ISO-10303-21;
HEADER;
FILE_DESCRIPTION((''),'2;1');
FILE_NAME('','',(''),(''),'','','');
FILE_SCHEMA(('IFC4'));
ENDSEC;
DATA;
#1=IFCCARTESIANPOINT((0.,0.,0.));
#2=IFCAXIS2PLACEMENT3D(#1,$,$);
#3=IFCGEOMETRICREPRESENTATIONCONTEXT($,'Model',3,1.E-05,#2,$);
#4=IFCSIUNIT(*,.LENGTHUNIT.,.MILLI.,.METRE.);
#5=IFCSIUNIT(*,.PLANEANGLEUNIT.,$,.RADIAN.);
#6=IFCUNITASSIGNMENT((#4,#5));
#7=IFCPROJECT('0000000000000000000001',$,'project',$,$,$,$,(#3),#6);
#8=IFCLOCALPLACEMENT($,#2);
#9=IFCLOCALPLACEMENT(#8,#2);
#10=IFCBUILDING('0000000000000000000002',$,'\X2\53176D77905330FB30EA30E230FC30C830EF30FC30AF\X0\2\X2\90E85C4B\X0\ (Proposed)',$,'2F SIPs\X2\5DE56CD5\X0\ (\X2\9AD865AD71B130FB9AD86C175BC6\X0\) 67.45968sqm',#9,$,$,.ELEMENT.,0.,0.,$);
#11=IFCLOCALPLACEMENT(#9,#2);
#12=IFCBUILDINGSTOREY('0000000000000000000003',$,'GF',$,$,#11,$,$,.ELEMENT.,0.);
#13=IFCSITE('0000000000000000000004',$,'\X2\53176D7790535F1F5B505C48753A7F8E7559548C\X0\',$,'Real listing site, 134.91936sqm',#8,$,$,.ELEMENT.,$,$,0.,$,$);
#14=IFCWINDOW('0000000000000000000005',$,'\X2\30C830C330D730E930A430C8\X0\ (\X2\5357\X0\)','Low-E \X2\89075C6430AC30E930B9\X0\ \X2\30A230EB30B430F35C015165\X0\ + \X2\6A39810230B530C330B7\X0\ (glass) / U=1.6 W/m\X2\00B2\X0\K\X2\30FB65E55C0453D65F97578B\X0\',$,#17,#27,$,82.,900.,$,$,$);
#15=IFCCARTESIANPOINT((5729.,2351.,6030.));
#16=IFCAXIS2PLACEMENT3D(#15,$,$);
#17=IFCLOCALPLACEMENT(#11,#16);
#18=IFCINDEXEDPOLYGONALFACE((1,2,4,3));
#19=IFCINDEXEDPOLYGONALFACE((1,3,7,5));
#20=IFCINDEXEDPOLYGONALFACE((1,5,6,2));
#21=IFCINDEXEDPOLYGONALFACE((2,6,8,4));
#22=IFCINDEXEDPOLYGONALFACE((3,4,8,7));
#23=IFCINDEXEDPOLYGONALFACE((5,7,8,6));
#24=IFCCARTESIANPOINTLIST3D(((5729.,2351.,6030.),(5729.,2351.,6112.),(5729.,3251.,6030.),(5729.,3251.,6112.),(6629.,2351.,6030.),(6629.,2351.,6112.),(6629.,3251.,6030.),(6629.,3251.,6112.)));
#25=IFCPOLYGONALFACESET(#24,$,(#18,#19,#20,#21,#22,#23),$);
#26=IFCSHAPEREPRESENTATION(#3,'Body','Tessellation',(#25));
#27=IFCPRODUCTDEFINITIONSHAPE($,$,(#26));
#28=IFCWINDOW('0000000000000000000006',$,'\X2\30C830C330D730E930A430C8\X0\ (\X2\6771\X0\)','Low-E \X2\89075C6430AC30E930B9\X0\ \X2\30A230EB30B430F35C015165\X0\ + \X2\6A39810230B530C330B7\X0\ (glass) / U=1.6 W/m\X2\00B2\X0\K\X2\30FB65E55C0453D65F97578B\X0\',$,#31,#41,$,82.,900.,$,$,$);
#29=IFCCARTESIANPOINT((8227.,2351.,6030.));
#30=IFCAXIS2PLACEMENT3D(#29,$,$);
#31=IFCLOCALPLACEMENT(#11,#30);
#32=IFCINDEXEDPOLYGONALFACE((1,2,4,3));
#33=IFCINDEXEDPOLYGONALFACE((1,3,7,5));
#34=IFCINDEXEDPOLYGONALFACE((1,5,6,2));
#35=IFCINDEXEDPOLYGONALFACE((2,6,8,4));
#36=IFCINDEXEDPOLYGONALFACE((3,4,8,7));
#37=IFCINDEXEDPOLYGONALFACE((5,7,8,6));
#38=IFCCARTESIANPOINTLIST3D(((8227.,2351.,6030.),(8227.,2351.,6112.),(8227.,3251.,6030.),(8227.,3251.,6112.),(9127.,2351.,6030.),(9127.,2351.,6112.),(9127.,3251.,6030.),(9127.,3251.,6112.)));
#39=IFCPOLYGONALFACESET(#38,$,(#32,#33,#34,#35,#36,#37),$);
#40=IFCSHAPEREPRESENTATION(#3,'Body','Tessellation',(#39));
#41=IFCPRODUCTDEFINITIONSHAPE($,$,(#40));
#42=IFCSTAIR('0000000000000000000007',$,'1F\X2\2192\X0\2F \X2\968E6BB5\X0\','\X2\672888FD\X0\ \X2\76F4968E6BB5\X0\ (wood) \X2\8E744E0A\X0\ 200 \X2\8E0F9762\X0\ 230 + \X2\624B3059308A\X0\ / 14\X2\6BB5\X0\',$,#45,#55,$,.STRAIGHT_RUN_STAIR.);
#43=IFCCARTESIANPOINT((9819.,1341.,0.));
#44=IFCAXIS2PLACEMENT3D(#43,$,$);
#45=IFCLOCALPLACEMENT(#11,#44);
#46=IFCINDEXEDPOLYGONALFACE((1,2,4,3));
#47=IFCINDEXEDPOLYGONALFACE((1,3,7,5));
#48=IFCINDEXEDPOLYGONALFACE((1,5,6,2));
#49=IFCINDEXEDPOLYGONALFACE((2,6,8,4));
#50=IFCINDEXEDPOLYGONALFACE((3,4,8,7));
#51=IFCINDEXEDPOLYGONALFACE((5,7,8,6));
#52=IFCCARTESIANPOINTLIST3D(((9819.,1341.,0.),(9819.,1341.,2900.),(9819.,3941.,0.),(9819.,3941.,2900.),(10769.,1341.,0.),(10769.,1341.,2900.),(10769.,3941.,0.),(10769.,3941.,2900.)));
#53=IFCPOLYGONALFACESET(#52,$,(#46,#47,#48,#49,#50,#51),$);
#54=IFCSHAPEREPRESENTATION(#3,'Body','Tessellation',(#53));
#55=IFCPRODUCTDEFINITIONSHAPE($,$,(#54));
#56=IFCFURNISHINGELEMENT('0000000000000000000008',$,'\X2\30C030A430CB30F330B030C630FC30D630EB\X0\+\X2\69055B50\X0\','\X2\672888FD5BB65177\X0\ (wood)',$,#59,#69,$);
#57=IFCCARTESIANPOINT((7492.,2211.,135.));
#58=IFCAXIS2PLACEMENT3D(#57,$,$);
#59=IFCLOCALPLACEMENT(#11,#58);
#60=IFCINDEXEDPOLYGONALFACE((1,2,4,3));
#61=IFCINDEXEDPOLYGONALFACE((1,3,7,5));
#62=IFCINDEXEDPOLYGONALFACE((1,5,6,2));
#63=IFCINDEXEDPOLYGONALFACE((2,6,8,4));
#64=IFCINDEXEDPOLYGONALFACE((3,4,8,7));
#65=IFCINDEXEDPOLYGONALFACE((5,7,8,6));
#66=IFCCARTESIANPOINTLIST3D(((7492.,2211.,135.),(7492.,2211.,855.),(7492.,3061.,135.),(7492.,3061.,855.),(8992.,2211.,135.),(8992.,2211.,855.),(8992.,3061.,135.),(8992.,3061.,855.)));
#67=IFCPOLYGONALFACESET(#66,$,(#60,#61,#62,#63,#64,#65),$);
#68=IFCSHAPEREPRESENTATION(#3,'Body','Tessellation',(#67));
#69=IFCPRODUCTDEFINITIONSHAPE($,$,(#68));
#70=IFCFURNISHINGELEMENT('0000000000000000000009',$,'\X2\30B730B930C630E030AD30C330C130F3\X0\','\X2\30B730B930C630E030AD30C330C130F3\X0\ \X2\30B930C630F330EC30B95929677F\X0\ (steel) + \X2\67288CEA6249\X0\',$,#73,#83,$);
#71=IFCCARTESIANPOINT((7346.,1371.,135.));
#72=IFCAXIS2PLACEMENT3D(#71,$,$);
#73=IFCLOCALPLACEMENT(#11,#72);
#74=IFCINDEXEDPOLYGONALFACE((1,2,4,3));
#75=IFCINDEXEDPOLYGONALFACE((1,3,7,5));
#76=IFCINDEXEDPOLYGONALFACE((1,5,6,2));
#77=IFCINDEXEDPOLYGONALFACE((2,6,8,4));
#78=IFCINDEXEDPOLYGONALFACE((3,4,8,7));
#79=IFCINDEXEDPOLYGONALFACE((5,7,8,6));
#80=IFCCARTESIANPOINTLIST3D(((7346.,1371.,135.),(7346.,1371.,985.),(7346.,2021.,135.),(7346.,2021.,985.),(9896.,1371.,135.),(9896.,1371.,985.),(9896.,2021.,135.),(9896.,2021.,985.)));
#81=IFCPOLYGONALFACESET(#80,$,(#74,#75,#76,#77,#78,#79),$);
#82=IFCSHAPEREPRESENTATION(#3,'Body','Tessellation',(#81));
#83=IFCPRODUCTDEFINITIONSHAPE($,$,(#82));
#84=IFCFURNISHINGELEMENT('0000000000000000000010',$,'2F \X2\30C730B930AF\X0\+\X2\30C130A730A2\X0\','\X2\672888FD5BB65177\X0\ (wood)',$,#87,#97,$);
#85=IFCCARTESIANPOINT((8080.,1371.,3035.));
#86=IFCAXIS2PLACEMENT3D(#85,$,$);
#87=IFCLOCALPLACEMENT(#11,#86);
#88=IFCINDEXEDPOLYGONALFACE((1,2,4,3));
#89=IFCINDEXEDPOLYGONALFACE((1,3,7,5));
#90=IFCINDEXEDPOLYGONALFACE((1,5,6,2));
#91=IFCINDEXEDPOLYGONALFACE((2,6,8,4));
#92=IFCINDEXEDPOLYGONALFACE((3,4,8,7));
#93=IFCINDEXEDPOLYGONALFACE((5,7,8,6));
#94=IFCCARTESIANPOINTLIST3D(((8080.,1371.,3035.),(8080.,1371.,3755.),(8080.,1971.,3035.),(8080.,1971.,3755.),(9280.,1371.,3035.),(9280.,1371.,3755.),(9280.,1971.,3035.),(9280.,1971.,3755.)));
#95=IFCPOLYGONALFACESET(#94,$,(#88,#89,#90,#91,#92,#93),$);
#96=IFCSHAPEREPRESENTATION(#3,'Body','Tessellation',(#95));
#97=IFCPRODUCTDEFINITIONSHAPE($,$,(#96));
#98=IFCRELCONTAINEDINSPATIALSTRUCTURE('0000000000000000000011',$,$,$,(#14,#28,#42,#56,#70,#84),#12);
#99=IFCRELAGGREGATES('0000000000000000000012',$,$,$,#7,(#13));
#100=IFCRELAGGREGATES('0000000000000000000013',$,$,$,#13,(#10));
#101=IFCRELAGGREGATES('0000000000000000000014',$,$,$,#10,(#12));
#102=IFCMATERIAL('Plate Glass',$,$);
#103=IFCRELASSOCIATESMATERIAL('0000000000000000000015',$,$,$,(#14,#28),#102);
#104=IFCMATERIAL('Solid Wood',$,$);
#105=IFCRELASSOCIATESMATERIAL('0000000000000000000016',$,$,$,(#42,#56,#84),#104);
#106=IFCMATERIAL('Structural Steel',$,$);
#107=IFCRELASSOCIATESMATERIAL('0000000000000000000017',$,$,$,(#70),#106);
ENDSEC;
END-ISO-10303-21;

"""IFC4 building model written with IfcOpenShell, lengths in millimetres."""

from ifc_helpers import new_model, si_unit, frame, frame_2d, origin, place, context, project, spatial, rectangle, extrude, material, element, save


model = new_model("IFC4")

# Units and contexts
model_context = context("Model", 3, precision=1e-05, world=origin())
ifc_project = project(units=[si_unit("LENGTHUNIT", "METRE", prefix="MILLI"), si_unit("PLANEANGLEUNIT", "RADIAN")], contexts=[model_context])

# Site, building, storey
site_placement = place(None, origin())
site = spatial("IfcSite", under=ifc_project, at=site_placement, Name="北海道弟子屈町美留和", ObjectType="Real listing site, 134.91936sqm", CompositionType="ELEMENT", RefElevation=0.0)
building_placement = place(site_placement, origin())
building = spatial("IfcBuilding", under=site, at=building_placement, Name="北海道・リモートワーク2部屋 (Proposed)", ObjectType="2F SIPs工法 (高断熱・高気密) 67.45968sqm", CompositionType="ELEMENT", ElevationOfRefHeight=0.0, ElevationOfTerrain=0.0)
storey_placement = place(building_placement, origin())
storey = spatial("IfcBuildingStorey", under=building, at=storey_placement, Name="GF", CompositionType="ELEMENT", Elevation=0.0)

# Shared definitions
ifc_material_1 = material(Name="Solid Wood")

# Shared definitions
ifc_material_2 = material(Name="Plate Glass")

# Windows
window_1_placement = place(storey_placement, frame((5729.0, 2351.0, 6030.0)))
element("IfcWindow", 1, at=window_1_placement, inside=storey, material=ifc_material_2, Name="トップライト (南)", Description="Low-E 複層ガラス アルゴン封入 + 樹脂サッシ (glass) / U=1.6 W/m²K・日射取得型", OverallHeight=82.0, OverallWidth=900.0, context=model_context, shape_type="SweptSolid", body=[
    extrude(rectangle(XDim=900.0, YDim=900.0, at=frame_2d((450.0, 450.0))), frame((5729.0, 2351.0, 6030.0)), (0.0, 0.0, 1.0), 82.0),
])
window_2_placement = place(storey_placement, frame((8227.0, 2351.0, 6030.0)))
element("IfcWindow", 2, at=window_2_placement, inside=storey, material=ifc_material_2, Name="トップライト (東)", Description="Low-E 複層ガラス アルゴン封入 + 樹脂サッシ (glass) / U=1.6 W/m²K・日射取得型", OverallHeight=82.0, OverallWidth=900.0, context=model_context, shape_type="SweptSolid", body=[
    extrude(rectangle(XDim=900.0, YDim=900.0, at=frame_2d((450.0, 450.0))), frame((8227.0, 2351.0, 6030.0)), (0.0, 0.0, 1.0), 82.0),
])

# Stair
stair_placement = place(storey_placement, frame((9819.0, 1341.0, 0.0)))
element("IfcStair", 3, at=stair_placement, inside=storey, material=ifc_material_1, Name="1F→2F 階段", Description="木製 直階段 (wood) 蹴上 200 踏面 230 + 手すり / 14段", PredefinedType="STRAIGHT_RUN_STAIR", context=model_context, shape_type="SweptSolid", body=[
    extrude(rectangle(XDim=950.0, YDim=2600.0, at=frame_2d((475.0, 1300.0))), frame((9819.0, 1341.0, 0.0)), (0.0, 0.0, 1.0), 2900.0),
])

# Furnishing elements
furnishing_1_placement = place(storey_placement, frame((7492.0, 2211.0, 135.0)))
element("IfcFurnishingElement", 4, at=furnishing_1_placement, inside=storey, material=ifc_material_1, Name="ダイニングテーブル+椅子", Description="木製家具 (wood)", context=model_context, shape_type="SweptSolid", body=[
    extrude(rectangle(XDim=1500.0, YDim=850.0, at=frame_2d((750.0, 425.0))), frame((7492.0, 2211.0, 135.0)), (0.0, 0.0, 1.0), 720.0),
])
ifc_material_3 = material(Name="Structural Steel")
furnishing_2_placement = place(storey_placement, frame((7346.0, 1371.0, 135.0)))
element("IfcFurnishingElement", 5, at=furnishing_2_placement, inside=storey, material=ifc_material_3, Name="システムキッチン", Description="システムキッチン ステンレス天板 (steel) + 木質扉", context=model_context, shape_type="SweptSolid", body=[
    extrude(rectangle(XDim=2550.0, YDim=650.0, at=frame_2d((1275.0, 325.0))), frame((7346.0, 1371.0, 135.0)), (0.0, 0.0, 1.0), 850.0),
])
furnishing_3_placement = place(storey_placement, frame((8080.0, 1371.0, 3035.0)))
element("IfcFurnishingElement", 6, at=furnishing_3_placement, inside=storey, material=ifc_material_1, Name="2F デスク+チェア", Description="木製家具 (wood)", context=model_context, shape_type="SweptSolid", body=[
    extrude(rectangle(XDim=1200.0, YDim=600.0, at=frame_2d((600.0, 300.0))), frame((8080.0, 1371.0, 3035.0)), (0.0, 0.0, 1.0), 720.0),
])

save(model, "model.ifc")
